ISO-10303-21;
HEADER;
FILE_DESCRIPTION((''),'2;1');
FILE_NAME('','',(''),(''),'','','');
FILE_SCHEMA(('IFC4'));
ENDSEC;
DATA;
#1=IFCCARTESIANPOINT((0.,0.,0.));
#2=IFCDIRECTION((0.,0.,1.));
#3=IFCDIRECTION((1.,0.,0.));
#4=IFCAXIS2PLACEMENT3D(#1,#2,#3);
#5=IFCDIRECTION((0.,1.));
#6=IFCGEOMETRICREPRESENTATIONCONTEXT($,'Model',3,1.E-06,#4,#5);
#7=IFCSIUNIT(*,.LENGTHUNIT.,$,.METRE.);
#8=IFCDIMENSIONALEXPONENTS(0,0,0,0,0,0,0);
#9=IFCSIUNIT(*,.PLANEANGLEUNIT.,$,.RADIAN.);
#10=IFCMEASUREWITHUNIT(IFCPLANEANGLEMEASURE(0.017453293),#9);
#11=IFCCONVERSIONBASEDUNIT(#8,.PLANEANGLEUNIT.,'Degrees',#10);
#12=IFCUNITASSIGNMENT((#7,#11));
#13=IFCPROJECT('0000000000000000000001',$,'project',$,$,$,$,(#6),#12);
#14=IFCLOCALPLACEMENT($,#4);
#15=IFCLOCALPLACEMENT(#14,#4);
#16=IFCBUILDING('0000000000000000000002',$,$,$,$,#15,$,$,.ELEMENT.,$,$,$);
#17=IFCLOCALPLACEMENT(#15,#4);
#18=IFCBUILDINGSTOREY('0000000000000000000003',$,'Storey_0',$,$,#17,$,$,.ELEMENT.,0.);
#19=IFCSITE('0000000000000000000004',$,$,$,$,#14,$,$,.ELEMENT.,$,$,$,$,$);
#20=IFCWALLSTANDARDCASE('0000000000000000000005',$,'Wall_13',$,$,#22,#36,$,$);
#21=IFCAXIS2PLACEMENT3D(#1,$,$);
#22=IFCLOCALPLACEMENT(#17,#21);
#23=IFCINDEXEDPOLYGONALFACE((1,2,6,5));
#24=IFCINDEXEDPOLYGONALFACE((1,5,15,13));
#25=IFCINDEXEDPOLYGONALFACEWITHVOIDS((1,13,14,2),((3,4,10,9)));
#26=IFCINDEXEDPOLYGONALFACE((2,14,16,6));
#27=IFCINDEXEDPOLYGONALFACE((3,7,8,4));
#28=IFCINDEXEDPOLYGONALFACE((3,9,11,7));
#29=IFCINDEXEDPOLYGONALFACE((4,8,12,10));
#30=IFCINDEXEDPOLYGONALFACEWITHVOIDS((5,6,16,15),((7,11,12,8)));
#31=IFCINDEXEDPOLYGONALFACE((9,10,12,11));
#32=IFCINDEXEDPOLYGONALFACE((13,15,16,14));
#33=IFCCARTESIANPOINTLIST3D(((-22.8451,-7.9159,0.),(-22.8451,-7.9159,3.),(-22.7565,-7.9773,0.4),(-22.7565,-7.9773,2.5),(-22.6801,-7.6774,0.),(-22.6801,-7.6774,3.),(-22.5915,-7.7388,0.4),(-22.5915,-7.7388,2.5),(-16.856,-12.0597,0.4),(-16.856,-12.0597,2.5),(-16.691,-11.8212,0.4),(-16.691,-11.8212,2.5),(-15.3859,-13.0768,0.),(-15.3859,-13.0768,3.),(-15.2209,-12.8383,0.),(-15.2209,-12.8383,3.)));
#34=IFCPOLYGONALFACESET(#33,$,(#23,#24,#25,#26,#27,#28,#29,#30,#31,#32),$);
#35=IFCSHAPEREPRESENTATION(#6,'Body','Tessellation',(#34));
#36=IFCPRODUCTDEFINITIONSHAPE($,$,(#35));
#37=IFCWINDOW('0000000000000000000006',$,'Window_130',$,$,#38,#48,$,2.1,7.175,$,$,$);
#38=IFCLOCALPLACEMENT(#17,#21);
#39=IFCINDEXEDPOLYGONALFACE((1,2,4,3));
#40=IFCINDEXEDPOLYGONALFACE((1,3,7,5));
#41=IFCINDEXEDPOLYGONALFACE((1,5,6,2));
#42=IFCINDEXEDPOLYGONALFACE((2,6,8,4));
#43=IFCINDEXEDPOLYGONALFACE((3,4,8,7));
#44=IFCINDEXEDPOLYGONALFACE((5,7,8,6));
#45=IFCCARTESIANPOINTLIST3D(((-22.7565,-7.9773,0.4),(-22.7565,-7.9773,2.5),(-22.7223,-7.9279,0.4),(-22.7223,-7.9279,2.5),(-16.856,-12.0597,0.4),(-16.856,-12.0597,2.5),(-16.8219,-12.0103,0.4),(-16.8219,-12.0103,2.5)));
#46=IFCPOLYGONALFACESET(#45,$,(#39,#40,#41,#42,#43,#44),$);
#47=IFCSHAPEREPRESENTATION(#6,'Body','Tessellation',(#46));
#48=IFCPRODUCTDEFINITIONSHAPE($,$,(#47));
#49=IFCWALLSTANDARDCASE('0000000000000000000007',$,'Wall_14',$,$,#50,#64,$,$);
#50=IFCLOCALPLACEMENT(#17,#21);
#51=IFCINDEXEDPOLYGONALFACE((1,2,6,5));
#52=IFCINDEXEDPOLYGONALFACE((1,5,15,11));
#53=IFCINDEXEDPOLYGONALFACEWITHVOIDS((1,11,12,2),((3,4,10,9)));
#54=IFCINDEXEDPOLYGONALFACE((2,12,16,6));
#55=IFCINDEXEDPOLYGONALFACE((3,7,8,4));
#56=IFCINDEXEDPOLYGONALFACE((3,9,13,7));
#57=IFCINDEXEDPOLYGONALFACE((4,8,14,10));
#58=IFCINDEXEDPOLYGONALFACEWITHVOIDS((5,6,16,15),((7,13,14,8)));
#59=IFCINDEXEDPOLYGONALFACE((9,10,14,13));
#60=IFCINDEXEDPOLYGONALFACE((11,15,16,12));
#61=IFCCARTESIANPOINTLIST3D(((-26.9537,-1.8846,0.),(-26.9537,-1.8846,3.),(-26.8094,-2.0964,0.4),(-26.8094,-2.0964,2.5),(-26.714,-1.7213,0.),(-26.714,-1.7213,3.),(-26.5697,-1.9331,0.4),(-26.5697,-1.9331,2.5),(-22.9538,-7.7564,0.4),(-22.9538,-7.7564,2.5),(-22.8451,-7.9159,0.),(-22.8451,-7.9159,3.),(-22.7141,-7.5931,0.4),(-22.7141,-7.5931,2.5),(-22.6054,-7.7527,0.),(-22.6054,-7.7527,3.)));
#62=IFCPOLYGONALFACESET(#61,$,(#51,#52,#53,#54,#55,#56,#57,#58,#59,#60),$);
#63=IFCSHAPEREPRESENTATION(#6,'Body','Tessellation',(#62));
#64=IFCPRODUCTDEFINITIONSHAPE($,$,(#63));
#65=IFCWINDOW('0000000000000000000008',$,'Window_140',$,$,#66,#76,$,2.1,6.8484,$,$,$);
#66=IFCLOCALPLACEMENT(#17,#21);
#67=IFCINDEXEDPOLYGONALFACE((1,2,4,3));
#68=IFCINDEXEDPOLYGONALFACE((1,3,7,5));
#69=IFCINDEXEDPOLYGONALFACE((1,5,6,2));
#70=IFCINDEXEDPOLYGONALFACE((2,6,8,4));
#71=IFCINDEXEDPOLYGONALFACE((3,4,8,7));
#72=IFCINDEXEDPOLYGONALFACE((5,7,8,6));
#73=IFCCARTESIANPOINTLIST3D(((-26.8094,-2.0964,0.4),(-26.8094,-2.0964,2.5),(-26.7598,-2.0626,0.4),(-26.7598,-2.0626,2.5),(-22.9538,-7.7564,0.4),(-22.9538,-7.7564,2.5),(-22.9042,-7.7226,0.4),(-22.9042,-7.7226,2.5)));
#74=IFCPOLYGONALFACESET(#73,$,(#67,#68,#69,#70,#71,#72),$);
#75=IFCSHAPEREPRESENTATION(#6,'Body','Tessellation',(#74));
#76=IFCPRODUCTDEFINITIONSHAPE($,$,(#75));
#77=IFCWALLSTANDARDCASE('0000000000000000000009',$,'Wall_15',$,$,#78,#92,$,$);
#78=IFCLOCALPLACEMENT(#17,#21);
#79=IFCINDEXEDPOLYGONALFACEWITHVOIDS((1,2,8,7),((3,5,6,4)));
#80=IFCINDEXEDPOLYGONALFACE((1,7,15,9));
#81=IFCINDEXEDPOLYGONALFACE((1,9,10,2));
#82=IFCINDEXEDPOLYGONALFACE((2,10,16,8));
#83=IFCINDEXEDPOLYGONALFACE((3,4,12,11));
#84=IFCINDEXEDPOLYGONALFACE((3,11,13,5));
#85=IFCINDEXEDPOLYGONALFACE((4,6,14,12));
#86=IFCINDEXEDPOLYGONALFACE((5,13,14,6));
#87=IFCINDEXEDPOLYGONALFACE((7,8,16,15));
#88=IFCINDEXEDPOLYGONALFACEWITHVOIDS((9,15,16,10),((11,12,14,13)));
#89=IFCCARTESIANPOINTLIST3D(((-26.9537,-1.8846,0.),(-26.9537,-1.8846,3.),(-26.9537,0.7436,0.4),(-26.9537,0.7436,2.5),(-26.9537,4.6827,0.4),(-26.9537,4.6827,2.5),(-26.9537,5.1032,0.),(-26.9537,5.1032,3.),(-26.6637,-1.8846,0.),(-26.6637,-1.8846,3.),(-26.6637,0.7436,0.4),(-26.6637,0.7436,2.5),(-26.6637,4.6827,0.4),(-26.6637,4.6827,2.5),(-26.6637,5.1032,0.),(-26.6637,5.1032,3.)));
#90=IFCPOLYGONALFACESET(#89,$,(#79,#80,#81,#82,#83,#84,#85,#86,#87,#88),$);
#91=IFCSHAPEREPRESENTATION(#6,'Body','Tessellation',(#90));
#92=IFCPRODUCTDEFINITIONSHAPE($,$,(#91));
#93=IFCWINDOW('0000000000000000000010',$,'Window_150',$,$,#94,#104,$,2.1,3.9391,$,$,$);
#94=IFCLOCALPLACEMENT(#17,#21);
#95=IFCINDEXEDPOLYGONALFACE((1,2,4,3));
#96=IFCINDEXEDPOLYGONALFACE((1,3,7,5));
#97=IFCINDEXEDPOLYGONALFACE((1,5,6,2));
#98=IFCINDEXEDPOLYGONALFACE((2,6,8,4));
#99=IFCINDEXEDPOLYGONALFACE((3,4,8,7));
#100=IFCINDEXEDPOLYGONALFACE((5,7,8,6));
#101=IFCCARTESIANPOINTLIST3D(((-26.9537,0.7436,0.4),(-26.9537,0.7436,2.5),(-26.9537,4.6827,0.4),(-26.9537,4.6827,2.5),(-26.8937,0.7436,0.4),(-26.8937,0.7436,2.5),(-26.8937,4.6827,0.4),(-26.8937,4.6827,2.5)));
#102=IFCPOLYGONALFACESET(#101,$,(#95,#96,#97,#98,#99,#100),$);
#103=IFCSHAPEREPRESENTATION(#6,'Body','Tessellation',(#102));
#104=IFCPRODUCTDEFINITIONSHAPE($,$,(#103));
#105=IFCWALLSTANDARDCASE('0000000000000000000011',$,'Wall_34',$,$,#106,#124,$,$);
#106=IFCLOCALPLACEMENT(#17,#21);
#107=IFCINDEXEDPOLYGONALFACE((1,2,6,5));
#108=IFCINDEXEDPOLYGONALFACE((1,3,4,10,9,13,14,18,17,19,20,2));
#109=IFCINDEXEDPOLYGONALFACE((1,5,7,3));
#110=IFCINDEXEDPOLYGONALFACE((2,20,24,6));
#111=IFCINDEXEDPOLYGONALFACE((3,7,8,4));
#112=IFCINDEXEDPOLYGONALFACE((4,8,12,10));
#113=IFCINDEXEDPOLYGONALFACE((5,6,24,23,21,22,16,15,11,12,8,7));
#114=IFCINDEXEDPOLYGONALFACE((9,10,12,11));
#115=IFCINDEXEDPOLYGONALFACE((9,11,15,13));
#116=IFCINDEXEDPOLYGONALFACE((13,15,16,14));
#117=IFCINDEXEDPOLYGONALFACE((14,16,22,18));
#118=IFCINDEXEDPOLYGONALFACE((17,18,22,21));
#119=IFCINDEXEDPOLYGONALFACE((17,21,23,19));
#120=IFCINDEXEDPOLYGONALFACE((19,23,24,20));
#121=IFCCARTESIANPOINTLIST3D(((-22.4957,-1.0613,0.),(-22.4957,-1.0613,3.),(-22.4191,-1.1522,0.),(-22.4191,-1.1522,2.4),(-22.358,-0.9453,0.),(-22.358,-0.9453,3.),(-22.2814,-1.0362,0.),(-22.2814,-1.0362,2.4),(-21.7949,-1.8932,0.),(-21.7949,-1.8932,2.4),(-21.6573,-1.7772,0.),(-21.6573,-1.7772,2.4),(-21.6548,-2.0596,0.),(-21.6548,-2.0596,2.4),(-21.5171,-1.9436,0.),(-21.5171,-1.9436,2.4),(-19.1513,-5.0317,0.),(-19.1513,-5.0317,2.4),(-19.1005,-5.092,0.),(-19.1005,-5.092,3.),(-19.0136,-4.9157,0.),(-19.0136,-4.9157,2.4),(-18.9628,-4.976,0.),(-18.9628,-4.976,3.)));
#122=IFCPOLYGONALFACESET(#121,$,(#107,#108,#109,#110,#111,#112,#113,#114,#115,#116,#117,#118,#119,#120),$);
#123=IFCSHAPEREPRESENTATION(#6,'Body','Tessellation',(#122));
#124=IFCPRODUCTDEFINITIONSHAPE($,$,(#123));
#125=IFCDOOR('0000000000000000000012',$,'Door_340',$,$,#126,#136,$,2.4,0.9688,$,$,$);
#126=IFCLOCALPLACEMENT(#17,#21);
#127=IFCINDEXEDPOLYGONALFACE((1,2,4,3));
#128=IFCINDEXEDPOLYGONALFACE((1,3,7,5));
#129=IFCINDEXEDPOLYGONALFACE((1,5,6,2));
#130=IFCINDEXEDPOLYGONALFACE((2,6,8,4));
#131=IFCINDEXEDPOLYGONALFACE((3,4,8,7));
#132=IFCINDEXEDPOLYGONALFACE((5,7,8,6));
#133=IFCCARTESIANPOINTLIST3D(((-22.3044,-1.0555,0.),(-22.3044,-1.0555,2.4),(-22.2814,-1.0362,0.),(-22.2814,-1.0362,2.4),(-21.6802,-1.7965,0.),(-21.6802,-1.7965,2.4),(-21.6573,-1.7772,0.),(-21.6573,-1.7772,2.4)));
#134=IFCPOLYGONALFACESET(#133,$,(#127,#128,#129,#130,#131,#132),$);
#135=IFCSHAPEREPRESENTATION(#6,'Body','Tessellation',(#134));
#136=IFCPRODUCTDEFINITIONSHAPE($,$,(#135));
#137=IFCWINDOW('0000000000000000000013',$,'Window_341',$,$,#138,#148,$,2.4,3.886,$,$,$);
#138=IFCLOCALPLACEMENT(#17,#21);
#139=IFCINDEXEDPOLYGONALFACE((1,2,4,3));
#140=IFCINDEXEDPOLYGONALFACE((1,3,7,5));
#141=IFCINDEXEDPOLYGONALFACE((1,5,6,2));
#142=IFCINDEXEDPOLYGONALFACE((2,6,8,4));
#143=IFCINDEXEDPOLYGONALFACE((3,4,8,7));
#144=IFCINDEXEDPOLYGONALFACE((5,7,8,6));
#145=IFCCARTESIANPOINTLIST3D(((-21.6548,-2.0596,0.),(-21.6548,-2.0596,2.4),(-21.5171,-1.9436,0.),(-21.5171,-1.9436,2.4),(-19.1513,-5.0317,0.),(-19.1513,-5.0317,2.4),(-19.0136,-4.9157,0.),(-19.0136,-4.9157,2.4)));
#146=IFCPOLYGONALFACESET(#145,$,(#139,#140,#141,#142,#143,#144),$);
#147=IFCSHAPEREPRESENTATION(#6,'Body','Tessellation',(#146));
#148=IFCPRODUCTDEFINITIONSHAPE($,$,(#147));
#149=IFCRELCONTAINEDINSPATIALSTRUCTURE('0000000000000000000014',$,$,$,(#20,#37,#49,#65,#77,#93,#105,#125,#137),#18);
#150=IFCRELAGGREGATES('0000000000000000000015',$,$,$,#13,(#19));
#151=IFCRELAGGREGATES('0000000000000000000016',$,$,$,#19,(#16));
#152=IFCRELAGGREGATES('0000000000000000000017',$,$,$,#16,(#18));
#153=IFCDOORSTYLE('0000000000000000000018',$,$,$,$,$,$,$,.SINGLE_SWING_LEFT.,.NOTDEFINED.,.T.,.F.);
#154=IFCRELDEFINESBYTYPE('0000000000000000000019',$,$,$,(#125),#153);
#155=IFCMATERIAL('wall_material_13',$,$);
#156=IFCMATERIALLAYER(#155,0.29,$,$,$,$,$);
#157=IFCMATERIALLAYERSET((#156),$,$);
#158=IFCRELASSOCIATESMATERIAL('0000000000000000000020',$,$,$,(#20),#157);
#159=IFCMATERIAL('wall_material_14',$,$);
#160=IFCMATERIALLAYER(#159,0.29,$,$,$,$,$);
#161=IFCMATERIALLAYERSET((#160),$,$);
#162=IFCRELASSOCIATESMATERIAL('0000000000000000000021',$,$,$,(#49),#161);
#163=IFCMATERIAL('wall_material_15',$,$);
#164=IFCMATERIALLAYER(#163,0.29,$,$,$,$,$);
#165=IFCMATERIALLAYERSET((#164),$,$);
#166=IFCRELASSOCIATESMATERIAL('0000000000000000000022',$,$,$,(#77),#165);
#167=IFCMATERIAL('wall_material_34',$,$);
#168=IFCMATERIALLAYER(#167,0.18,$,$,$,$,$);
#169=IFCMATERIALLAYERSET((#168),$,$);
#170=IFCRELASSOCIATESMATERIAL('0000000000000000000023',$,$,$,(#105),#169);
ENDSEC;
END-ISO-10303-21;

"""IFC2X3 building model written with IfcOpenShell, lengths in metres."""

from ifc_helpers import new_model, entity, si_unit, converted_unit, direction, frame, frame_2d, origin_with_axes, place, context, project, spatial, polyline, rectangle, outline, extrude, material, layer, layer_set, layer_usage, type_object, element, fill, save


model = new_model("IFC2X3")

# Units and contexts
model_context = context("Model", 3, precision=1e-06, world=origin_with_axes(), true_north=direction((0.0, 1.0)))
ifc_project = project(units=[si_unit("LENGTHUNIT", "METRE"), converted_unit("PLANEANGLEUNIT", "Degrees", entity("IfcPlaneAngleMeasure", 0.017453293), si_unit("PLANEANGLEUNIT", "RADIAN"), dimensions=[0, 0, 0, 0, 0, 0, 0])], contexts=[model_context])

# Site, building, storey
site_placement = place(None, origin_with_axes())
site = spatial("IfcSite", under=ifc_project, at=site_placement, CompositionType="ELEMENT")
building_placement = place(site_placement, origin_with_axes())
building = spatial("IfcBuilding", under=site, at=building_placement, CompositionType="ELEMENT")
storey_placement = place(building_placement, origin_with_axes())
storey = spatial("IfcBuildingStorey", under=building, at=storey_placement, Name="Storey_0", CompositionType="ELEMENT", Elevation=0.0)

# Walls, openings, windows
ifc_material_1 = material(Name="wall_material_13")
ifc_layer_1 = layer(ifc_material_1, 0.29)
ifc_layer_set_1 = layer_set([ifc_layer_1])
ifc_layer_usage_1 = layer_usage(ifc_layer_set_1, "AXIS2", "NEGATIVE", 0.0)
wall_1_placement = place(storey_placement, frame((-15.3859, -13.0768, 0.0), z_axis=(0.0, 0.0, 1.0), x_axis=(-0.822355, 0.568974, 0.0)))
wall_1 = element("IfcWallStandardCase", 1, at=wall_1_placement, inside=storey, material=ifc_layer_usage_1, Name="Wall_13", context=model_context, shape_type="SweptSolid", body=[
    extrude(outline(polyline([(0.0, 0.0), (9.0705, 0.0), (9.0705, -0.29), (0.0, -0.29), (0.0, 0.0)])), origin_with_axes(), (0.0, 0.0, 1.0), 3.0),
])
opening_1_placement = place(wall_1_placement, frame((1.7877, 0.0, 0.4), z_axis=(0.0, 0.0, 1.0), x_axis=(1.0, 0.0, 0.0)))
opening_1 = element("IfcOpeningElement", 2, at=opening_1_placement, cuts=wall_1, context=model_context, shape_type="SweptSolid", body=[
    extrude(rectangle(XDim=7.175, YDim=2.1, at=frame_2d((1.05, -3.5875), x_axis=(0.0, 1.0))), frame((0.0, 0.01, 0.0), z_axis=(0.0, -1.0, 0.0), x_axis=(0.0, 0.0, 1.0)), (0.0, 0.0, 1.0), 0.31),
])
window_1_placement = place(storey_placement, frame((0.0, 0.0, 0.4), z_axis=(0.0, 0.0, 1.0), x_axis=(1.0, 0.0, 0.0)))
window_1 = element("IfcWindow", 3, at=window_1_placement, inside=storey, Name="Window_130", OverallHeight=2.1, OverallWidth=7.175, context=model_context, shape_type="SweptSolid", body=[
    extrude(outline(polyline([(-16.856, -12.0597), (-22.7565, -7.9773), (-22.7223, -7.9279), (-16.8219, -12.0103), (-16.856, -12.0597)])), origin_with_axes(), (0.0, 0.0, 1.0), 2.1),
])
fill(opening_1, window_1)
ifc_material_2 = material(Name="wall_material_14")
ifc_layer_2 = layer(ifc_material_2, 0.29)
ifc_layer_set_2 = layer_set([ifc_layer_2])
ifc_layer_usage_2 = layer_usage(ifc_layer_set_2, "AXIS2", "NEGATIVE", 0.0)
wall_2_placement = place(storey_placement, frame((-22.8451, -7.9159, 0.0), z_axis=(0.0, 0.0, 1.0), x_axis=(-0.562987, 0.826466, 0.0)))
wall_2 = element("IfcWallStandardCase", 4, at=wall_2_placement, inside=storey, material=ifc_layer_usage_2, Name="Wall_14", context=model_context, shape_type="SweptSolid", body=[
    extrude(outline(polyline([(0.0, 0.0), (7.2978, 0.0), (7.2978, -0.29), (0.0, -0.29), (0.0, 0.0)])), origin_with_axes(), (0.0, 0.0, 1.0), 3.0),
])
opening_2_placement = place(wall_2_placement, frame((0.1931, 0.0, 0.4), z_axis=(0.0, 0.0, 1.0), x_axis=(1.0, 0.0, 0.0)))
opening_2 = element("IfcOpeningElement", 5, at=opening_2_placement, cuts=wall_2, context=model_context, shape_type="SweptSolid", body=[
    extrude(rectangle(XDim=6.8484, YDim=2.1, at=frame_2d((1.05, -3.4242), x_axis=(0.0, 1.0))), frame((0.0, 0.01, 0.0), z_axis=(0.0, -1.0, 0.0), x_axis=(0.0, 0.0, 1.0)), (0.0, 0.0, 1.0), 0.31),
])
window_2_placement = place(storey_placement, frame((0.0, 0.0, 0.4), z_axis=(0.0, 0.0, 1.0), x_axis=(1.0, 0.0, 0.0)))
window_2 = element("IfcWindow", 6, at=window_2_placement, inside=storey, Name="Window_140", OverallHeight=2.1, OverallWidth=6.8484, context=model_context, shape_type="SweptSolid", body=[
    extrude(outline(polyline([(-22.9538, -7.7564), (-26.8094, -2.0964), (-26.7598, -2.0626), (-22.9042, -7.7226), (-22.9538, -7.7564)])), origin_with_axes(), (0.0, 0.0, 1.0), 2.1),
])
fill(opening_2, window_2)
ifc_material_3 = material(Name="wall_material_15")
ifc_layer_3 = layer(ifc_material_3, 0.29)
ifc_layer_set_3 = layer_set([ifc_layer_3])
ifc_layer_usage_3 = layer_usage(ifc_layer_set_3, "AXIS2", "NEGATIVE", 0.0)
wall_3_placement = place(storey_placement, frame((-26.9537, -1.8846, 0.0), z_axis=(0.0, 0.0, 1.0), x_axis=(0.0, 1.0, 0.0)))
wall_3 = element("IfcWallStandardCase", 7, at=wall_3_placement, inside=storey, material=ifc_layer_usage_3, Name="Wall_15", context=model_context, shape_type="SweptSolid", body=[
    extrude(outline(polyline([(0.0, 0.0), (6.9878, 0.0), (6.9878, -0.29), (0.0, -0.29), (0.0, 0.0)])), origin_with_axes(), (0.0, 0.0, 1.0), 3.0),
])
opening_3_placement = place(wall_3_placement, frame((2.6282, 0.0, 0.4), z_axis=(0.0, 0.0, 1.0), x_axis=(1.0, 0.0, 0.0)))
opening_3 = element("IfcOpeningElement", 8, at=opening_3_placement, cuts=wall_3, context=model_context, shape_type="SweptSolid", body=[
    extrude(rectangle(XDim=3.9391, YDim=2.1, at=frame_2d((1.05, -1.9695), x_axis=(0.0, 1.0))), frame((0.0, 0.01, 0.0), z_axis=(0.0, -1.0, 0.0), x_axis=(0.0, 0.0, 1.0)), (0.0, 0.0, 1.0), 0.31),
])
window_3_placement = place(storey_placement, frame((0.0, 0.0, 0.4), z_axis=(0.0, 0.0, 1.0), x_axis=(1.0, 0.0, 0.0)))
window_3 = element("IfcWindow", 9, at=window_3_placement, inside=storey, Name="Window_150", OverallHeight=2.1, OverallWidth=3.9391, context=model_context, shape_type="SweptSolid", body=[
    extrude(outline(polyline([(-26.9537, 0.7436), (-26.9537, 4.6827), (-26.8937, 4.6827), (-26.8937, 0.7436), (-26.9537, 0.7436)])), origin_with_axes(), (0.0, 0.0, 1.0), 2.1),
])
fill(opening_3, window_3)

# Wall, openings, door, window
ifc_material_4 = material(Name="wall_material_34")
ifc_layer_4 = layer(ifc_material_4, 0.18)
ifc_layer_set_4 = layer_set([ifc_layer_4])
ifc_layer_usage_4 = layer_usage(ifc_layer_set_4, "AXIS2", "NEGATIVE", 0.0)
wall_4_placement = place(storey_placement, frame((-22.358, -0.9453, 0.0), z_axis=(0.0, 0.0, 1.0), x_axis=(0.644235, -0.764828, 0.0)))
wall_4 = element("IfcWallStandardCase", 10, at=wall_4_placement, inside=storey, material=ifc_layer_usage_4, Name="Wall_34", context=model_context, shape_type="SweptSolid", body=[
    extrude(outline(polyline([(0.0, 0.0), (5.2701, 0.0), (5.2701, -0.18), (0.0, -0.18), (0.0, 0.0)])), origin_with_axes(), (0.0, 0.0, 1.0), 3.0),
])
opening_4_placement = place(wall_4_placement, frame((0.1189, 0.0, 0.0), z_axis=(0.0, 0.0, 1.0), x_axis=(1.0, 0.0, 0.0)))
opening_4 = element("IfcOpeningElement", 11, at=opening_4_placement, cuts=wall_4, context=model_context, shape_type="SweptSolid", body=[
    extrude(rectangle(XDim=0.9688, YDim=2.4, at=frame_2d((1.2, -0.4844), x_axis=(0.0, 1.0))), frame((0.0, 0.01, 0.0), z_axis=(0.0, -1.0, 0.0), x_axis=(0.0, 0.0, 1.0)), (0.0, 0.0, 1.0), 0.2),
])
opening_5_placement = place(wall_4_placement, frame((1.3053, 0.0, 0.0), z_axis=(0.0, 0.0, 1.0), x_axis=(1.0, 0.0, 0.0)))
opening_5 = element("IfcOpeningElement", 12, at=opening_5_placement, cuts=wall_4, context=model_context, shape_type="SweptSolid", body=[
    extrude(rectangle(XDim=3.886, YDim=2.4, at=frame_2d((1.2, -1.943), x_axis=(0.0, 1.0))), frame((0.0, 0.01, 0.0), z_axis=(0.0, -1.0, 0.0), x_axis=(0.0, 0.0, 1.0)), (0.0, 0.0, 1.0), 0.2),
])
door_style_1 = type_object("IfcDoorStyle", ConstructionType="NOTDEFINED", OperationType="SINGLE_SWING_LEFT", ParameterTakesPrecedence=True, Sizeable=False)
door_1_placement = place(storey_placement, origin_with_axes())
door_1 = element("IfcDoor", 13, at=door_1_placement, inside=storey, type_object=door_style_1, Name="Door_340", OverallHeight=2.4, OverallWidth=0.9688, context=model_context, shape_type="SweptSolid", body=[
    extrude(outline(polyline([(-22.2814, -1.0362), (-21.6573, -1.7772), (-21.6802, -1.7965), (-22.3044, -1.0555), (-22.2814, -1.0362)])), origin_with_axes(), (0.0, 0.0, 1.0), 2.4),
])
fill(opening_4, door_1)
window_4_placement = place(storey_placement, origin_with_axes())
window_4 = element("IfcWindow", 14, at=window_4_placement, inside=storey, Name="Window_341", OverallHeight=2.4, OverallWidth=3.886, context=model_context, shape_type="SweptSolid", body=[
    extrude(outline(polyline([(-21.5171, -1.9436), (-19.0136, -4.9157), (-19.1513, -5.0317), (-21.6548, -2.0596), (-21.5171, -1.9436)])), origin_with_axes(), (0.0, 0.0, 1.0), 2.4),
])
fill(opening_5, window_4)

save(model, "model.ifc")
